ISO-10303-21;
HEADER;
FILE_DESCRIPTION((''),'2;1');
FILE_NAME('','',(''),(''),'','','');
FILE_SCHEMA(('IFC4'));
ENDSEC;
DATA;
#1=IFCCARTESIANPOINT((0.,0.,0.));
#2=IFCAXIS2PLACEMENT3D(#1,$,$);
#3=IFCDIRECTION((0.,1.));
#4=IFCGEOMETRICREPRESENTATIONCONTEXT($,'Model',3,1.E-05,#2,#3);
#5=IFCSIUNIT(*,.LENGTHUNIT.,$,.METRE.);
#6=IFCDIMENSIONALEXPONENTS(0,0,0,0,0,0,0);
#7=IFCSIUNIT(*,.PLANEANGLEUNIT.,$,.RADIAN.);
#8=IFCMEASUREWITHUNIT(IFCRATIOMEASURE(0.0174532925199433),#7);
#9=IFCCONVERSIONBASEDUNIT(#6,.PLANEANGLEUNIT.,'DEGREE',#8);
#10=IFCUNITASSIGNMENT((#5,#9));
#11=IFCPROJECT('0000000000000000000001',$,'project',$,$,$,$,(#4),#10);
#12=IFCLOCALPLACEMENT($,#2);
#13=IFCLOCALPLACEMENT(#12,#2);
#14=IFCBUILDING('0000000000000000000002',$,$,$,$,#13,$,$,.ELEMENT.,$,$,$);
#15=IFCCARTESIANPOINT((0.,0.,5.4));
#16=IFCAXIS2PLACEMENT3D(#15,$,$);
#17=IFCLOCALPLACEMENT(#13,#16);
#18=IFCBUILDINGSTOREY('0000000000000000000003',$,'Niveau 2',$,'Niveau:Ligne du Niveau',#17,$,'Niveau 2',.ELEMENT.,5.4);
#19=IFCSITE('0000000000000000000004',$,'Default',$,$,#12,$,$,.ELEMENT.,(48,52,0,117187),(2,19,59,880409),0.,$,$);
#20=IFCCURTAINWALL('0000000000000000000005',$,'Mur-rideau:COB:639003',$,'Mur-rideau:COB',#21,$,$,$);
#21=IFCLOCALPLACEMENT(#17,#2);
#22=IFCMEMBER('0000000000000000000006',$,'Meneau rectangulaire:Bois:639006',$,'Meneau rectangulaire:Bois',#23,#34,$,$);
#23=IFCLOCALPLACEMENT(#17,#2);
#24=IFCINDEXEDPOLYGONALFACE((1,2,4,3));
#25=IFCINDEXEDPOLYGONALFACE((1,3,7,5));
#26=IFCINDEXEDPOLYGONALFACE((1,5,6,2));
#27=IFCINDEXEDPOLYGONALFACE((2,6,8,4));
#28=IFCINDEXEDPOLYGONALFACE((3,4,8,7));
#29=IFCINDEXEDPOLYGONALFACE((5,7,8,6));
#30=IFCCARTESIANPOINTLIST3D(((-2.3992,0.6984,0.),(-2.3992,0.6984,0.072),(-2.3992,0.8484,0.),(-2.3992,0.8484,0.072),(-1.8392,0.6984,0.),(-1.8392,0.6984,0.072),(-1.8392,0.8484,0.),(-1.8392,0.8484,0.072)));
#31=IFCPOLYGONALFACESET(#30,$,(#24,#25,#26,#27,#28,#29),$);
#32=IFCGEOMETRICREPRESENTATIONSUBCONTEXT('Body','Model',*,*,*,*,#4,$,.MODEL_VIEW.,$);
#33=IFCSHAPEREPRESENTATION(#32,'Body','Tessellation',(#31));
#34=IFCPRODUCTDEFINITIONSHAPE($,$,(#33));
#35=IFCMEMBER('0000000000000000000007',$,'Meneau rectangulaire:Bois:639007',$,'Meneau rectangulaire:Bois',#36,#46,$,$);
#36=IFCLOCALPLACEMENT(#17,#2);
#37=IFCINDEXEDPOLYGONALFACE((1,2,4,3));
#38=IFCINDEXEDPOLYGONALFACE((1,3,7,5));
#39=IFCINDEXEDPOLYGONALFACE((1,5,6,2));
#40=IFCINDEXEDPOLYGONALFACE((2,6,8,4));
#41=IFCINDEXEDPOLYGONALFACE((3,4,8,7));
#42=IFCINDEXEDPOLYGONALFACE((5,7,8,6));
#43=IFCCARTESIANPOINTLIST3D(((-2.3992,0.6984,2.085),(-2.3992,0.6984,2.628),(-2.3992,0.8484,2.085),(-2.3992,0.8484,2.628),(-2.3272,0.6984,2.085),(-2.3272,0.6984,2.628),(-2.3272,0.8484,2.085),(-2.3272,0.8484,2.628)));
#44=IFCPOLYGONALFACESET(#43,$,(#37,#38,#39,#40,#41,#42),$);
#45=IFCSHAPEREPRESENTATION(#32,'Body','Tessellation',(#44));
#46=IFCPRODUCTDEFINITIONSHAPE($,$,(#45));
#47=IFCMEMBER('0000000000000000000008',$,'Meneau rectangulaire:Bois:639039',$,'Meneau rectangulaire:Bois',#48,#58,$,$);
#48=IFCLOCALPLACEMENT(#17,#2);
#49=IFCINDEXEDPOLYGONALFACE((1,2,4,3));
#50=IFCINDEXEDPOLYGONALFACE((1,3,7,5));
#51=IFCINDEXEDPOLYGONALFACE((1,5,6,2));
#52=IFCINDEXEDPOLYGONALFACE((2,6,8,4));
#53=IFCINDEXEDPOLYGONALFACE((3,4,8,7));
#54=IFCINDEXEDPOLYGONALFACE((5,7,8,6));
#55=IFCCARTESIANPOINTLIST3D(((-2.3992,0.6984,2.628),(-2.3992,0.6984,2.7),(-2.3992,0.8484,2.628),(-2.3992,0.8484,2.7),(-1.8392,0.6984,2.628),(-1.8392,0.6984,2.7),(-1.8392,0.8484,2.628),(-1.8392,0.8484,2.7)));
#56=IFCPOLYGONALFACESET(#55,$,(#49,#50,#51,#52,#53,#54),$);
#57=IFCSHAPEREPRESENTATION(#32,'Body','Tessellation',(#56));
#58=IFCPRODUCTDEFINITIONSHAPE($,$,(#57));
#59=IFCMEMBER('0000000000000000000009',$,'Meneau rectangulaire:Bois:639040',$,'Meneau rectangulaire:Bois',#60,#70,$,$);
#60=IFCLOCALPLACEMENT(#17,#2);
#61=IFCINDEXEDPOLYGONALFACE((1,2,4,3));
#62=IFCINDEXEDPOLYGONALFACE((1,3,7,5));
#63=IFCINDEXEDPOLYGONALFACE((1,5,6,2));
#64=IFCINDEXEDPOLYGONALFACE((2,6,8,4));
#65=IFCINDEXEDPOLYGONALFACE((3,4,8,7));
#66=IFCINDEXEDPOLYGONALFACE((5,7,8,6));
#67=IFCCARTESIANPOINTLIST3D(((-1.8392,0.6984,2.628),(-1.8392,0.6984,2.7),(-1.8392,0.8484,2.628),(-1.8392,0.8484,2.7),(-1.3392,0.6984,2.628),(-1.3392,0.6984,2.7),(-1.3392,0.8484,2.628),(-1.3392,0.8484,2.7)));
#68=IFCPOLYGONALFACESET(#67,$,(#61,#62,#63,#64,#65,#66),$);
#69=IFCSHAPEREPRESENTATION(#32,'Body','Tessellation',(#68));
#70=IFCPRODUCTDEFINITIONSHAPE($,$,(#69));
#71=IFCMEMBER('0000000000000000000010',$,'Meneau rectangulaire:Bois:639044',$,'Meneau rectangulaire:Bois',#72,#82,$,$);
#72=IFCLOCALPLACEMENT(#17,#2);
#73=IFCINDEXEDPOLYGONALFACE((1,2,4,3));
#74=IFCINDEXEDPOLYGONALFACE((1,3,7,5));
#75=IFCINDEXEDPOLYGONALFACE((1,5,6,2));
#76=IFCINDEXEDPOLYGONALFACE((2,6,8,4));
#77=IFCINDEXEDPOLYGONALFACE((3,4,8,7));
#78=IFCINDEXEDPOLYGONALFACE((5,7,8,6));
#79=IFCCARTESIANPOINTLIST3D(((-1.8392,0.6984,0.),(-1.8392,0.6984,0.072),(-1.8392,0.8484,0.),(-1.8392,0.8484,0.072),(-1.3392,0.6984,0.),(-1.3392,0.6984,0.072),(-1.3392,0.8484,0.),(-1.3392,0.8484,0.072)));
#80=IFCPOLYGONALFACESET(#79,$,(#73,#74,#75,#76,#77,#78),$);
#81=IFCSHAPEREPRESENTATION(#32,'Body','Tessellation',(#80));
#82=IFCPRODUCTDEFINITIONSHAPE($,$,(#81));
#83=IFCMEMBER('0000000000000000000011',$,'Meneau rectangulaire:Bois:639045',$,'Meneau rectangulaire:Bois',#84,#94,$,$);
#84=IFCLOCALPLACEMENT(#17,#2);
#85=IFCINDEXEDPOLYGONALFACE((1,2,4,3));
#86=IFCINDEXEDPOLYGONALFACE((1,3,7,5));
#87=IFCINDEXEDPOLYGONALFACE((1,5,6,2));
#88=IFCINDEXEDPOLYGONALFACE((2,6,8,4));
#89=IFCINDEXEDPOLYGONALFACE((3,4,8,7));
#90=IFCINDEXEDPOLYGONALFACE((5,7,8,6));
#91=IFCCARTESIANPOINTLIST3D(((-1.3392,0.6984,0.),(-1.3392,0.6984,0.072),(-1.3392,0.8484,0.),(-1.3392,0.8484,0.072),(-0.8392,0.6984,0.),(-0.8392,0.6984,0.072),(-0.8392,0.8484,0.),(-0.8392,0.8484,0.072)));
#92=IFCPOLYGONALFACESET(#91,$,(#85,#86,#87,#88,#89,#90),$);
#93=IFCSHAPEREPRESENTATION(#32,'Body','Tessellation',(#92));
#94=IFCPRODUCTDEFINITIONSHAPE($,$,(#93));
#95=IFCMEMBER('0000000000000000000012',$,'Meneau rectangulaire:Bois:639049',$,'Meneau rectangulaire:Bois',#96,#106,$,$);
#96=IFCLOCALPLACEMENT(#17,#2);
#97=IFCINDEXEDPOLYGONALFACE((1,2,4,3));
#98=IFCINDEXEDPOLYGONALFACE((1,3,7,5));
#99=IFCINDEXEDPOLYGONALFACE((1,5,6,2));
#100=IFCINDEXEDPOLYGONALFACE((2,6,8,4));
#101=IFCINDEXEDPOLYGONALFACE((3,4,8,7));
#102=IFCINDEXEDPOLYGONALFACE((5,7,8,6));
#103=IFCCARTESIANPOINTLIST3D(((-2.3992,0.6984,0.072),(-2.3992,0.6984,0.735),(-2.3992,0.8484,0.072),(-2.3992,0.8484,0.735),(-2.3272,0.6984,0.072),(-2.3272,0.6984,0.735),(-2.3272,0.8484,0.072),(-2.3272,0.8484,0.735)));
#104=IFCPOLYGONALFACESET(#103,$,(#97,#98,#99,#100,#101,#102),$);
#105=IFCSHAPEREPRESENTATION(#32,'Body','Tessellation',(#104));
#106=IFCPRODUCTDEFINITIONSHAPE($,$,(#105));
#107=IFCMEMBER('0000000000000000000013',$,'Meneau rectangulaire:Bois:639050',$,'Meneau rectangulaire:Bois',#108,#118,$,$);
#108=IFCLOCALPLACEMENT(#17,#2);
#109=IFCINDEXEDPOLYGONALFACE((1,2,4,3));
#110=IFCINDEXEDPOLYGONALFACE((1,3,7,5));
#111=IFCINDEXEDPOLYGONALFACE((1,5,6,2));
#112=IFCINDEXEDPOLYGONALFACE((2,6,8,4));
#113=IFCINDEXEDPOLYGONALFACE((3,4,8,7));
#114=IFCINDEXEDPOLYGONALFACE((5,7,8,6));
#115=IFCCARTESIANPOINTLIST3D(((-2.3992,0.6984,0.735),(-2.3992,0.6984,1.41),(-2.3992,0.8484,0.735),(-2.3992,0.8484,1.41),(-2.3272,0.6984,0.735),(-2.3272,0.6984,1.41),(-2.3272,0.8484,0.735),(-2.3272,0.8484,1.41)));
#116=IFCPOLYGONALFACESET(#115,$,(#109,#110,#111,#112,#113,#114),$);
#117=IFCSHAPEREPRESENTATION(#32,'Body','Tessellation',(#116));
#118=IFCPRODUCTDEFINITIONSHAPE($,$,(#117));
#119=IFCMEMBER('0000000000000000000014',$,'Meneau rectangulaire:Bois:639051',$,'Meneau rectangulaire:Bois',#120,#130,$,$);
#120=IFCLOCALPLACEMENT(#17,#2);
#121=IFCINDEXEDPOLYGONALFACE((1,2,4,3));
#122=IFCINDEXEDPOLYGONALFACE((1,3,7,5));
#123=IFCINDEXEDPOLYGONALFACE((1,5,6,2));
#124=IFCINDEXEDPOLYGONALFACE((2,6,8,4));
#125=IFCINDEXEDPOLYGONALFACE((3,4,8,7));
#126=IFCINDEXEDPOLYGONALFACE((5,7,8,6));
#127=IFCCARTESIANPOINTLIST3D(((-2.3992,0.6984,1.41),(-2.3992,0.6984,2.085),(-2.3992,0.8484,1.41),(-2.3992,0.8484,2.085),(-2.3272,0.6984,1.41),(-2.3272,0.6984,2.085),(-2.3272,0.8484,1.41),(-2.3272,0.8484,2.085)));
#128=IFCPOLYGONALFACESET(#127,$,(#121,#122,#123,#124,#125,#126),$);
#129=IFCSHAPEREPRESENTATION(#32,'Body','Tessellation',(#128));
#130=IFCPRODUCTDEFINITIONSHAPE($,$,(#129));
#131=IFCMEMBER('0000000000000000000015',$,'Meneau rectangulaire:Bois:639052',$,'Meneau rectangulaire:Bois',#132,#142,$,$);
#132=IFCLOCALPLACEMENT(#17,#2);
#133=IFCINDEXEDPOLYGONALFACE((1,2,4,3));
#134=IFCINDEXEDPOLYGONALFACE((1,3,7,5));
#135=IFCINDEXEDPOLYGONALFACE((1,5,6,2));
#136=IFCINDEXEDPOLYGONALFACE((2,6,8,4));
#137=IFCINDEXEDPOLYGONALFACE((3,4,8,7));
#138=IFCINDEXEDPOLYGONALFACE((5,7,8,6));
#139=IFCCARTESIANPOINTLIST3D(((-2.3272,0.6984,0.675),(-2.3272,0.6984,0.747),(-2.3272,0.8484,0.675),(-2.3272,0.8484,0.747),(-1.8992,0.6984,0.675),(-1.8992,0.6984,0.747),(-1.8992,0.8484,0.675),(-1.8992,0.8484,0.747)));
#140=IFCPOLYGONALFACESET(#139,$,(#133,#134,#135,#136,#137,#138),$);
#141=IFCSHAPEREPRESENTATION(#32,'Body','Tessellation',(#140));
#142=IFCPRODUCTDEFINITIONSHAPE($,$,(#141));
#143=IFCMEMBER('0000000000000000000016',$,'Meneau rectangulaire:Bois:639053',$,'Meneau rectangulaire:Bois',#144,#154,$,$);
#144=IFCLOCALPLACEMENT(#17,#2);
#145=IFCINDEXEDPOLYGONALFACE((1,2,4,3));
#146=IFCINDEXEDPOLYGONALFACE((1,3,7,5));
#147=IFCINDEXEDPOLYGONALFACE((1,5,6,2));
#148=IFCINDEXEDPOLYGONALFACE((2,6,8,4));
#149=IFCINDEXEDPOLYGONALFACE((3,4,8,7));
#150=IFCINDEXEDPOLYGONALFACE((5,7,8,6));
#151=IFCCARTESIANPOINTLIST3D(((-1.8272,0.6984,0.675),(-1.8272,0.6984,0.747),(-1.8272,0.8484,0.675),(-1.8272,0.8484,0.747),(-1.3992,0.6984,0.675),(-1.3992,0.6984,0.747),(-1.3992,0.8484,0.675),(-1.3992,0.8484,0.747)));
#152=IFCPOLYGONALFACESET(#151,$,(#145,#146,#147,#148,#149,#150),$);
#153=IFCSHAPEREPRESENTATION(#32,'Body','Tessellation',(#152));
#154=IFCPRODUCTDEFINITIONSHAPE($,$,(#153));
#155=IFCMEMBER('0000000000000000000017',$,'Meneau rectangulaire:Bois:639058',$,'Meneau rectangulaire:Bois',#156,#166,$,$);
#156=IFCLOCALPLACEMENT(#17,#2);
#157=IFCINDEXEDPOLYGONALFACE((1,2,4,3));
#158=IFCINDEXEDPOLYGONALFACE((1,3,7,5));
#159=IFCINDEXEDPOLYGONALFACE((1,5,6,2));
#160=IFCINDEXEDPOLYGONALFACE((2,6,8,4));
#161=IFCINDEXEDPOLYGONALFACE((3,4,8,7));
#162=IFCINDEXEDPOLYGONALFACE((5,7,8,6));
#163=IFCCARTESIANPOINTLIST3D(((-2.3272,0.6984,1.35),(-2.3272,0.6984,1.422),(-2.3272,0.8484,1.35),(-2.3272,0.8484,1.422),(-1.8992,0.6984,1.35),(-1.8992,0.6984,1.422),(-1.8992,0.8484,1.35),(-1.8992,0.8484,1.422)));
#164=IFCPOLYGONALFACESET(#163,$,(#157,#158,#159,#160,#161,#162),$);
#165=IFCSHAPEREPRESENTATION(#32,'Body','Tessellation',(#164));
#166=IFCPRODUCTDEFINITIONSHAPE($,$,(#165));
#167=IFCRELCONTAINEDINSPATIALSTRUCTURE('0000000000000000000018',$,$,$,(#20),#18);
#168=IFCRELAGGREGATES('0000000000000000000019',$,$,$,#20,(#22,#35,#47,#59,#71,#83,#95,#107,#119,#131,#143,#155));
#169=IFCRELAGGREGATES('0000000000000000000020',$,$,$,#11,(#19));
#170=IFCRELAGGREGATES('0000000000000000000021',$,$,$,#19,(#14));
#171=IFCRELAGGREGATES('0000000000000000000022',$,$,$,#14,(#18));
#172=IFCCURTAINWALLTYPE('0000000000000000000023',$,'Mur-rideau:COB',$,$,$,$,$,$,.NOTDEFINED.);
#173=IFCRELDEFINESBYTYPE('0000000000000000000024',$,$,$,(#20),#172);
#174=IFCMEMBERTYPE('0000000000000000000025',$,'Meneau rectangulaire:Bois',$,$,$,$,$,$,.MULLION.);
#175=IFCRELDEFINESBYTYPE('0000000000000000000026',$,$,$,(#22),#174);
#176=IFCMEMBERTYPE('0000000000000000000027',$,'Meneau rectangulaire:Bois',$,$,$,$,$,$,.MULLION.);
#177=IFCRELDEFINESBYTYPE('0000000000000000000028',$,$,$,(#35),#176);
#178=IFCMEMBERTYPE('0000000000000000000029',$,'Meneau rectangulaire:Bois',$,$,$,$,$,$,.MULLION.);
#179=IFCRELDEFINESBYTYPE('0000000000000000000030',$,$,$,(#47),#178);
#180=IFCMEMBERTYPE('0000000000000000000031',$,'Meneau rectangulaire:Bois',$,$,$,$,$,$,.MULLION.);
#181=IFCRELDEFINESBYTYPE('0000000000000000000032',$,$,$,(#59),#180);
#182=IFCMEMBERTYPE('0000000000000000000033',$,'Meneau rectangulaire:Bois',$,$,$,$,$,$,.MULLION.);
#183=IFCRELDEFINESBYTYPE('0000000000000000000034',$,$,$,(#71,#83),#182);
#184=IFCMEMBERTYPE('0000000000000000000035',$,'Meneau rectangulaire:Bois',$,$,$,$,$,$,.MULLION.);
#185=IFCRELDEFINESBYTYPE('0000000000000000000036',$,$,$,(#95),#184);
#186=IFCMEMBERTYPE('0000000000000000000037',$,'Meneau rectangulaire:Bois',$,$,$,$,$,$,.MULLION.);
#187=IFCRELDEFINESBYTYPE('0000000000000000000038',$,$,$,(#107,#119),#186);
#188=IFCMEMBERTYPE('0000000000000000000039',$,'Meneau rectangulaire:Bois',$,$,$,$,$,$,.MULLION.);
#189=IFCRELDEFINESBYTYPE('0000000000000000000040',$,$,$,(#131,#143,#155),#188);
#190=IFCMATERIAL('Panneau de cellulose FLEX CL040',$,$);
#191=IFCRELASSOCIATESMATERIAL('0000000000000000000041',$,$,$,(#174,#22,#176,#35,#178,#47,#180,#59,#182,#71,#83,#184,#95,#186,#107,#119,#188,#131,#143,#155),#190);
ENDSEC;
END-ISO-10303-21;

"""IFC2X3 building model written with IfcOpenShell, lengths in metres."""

from ifc_helpers import new_model, entity, si_unit, converted_unit, direction, frame, origin, origin_2d_with_axis, place, context, subcontext, project, spatial, rectangle, extrude, source, transform, mapped, material, type_object, type_shapes, element, aggregate, save


model = new_model("IFC2X3")

# Units and contexts
model_context = context("Model", 3, precision=1e-05, world=origin(), true_north=direction((0.0, 1.0)))
body_context = subcontext(model_context, "Body", "Model", "MODEL_VIEW")
ifc_project = project(units=[si_unit("LENGTHUNIT", "METRE"), converted_unit("PLANEANGLEUNIT", "DEGREE", entity("IfcRatioMeasure", 0.0174532925199433), si_unit("PLANEANGLEUNIT", "RADIAN"), dimensions=[0, 0, 0, 0, 0, 0, 0])], contexts=[model_context])

# Site, building, storey
site_placement = place(None, origin())
site = spatial("IfcSite", under=ifc_project, at=site_placement, Name="Default", CompositionType="ELEMENT", RefLatitude=(48, 52, 0, 117187), RefLongitude=(2, 19, 59, 880409), RefElevation=0.0)
building_placement = place(site_placement, origin())
building = spatial("IfcBuilding", under=site, at=building_placement, CompositionType="ELEMENT")
storey_placement = place(building_placement, frame((0.0, 0.0, 5.4)))
storey = spatial("IfcBuildingStorey", under=building, at=storey_placement, Name="Niveau 2", ObjectType="Niveau:Ligne du Niveau", LongName="Niveau 2", CompositionType="ELEMENT", Elevation=5.4)

# Curtain wall, members
curtain_wall_type_1 = type_object("IfcCurtainWallType", Name="Mur-rideau:COB", PredefinedType="NOTDEFINED")
curtain_wall_1_placement = place(storey_placement, frame((0.0, 0.0, -5.4)))
curtain_wall_1 = element("IfcCurtainWall", 1, at=curtain_wall_1_placement, inside=storey, type_object=curtain_wall_type_1, Name="Mur-rideau:COB:639003", ObjectType="Mur-rideau:COB")
ifc_material_1 = material(Name="Panneau de cellulose FLEX CL040")
member_type_1 = type_object("IfcMemberType", Name="Meneau rectangulaire:Bois", PredefinedType="MULLION", material=ifc_material_1)
shared_shape_1 = source(origin(), body_context, "Body", "SweptSolid", [
    extrude(rectangle(XDim=0.15, YDim=0.072, at=origin_2d_with_axis()), frame((-0.036, 0.0, -0.56), z_axis=(0.0, 0.0, 1.0), x_axis=(0.0, -1.0, 0.0)), (0.0, 0.0, 1.0), 0.56),
])
type_shapes(member_type_1, [shared_shape_1])
member_1_placement = place(storey_placement, frame((-2.3992, 0.7734, 0.0), z_axis=(-1.0, 0.0, 0.0), x_axis=(0.0, 0.0, -1.0)))
member_1 = element("IfcMember", 2, at=member_1_placement, type_object=member_type_1, material=ifc_material_1, Name="Meneau rectangulaire:Bois:639006", ObjectType="Meneau rectangulaire:Bois", context=body_context, shape_type="MappedRepresentation", body=[
    mapped(shared_shape_1, transform((0.0, 0.0, 0.0), scale=1.0)),
])
member_type_2 = type_object("IfcMemberType", Name="Meneau rectangulaire:Bois", PredefinedType="MULLION", material=ifc_material_1)
shared_shape_2 = source(origin(), body_context, "Body", "SweptSolid", [
    extrude(rectangle(XDim=0.15, YDim=0.072, at=origin_2d_with_axis()), frame((-0.036, 0.0, -0.543), z_axis=(0.0, 0.0, 1.0), x_axis=(0.0, -1.0, 0.0)), (0.0, 0.0, 1.0), 0.543),
])
type_shapes(member_type_2, [shared_shape_2])
member_2_placement = place(storey_placement, frame((-2.3992, 0.7734, 2.628), z_axis=(0.0, 0.0, 1.0), x_axis=(-1.0, 0.0, 0.0)))
member_2 = element("IfcMember", 3, at=member_2_placement, type_object=member_type_2, material=ifc_material_1, Name="Meneau rectangulaire:Bois:639007", ObjectType="Meneau rectangulaire:Bois", context=body_context, shape_type="MappedRepresentation", body=[
    mapped(shared_shape_2, transform((0.0, 0.0, 0.0), scale=1.0)),
])
member_type_3 = type_object("IfcMemberType", Name="Meneau rectangulaire:Bois", PredefinedType="MULLION", material=ifc_material_1)
shared_shape_3 = source(origin(), body_context, "Body", "SweptSolid", [
    extrude(rectangle(XDim=0.15, YDim=0.072, at=origin_2d_with_axis()), frame((-0.036, 0.0, -0.56), z_axis=(0.0, 0.0, 1.0), x_axis=(0.0, -1.0, 0.0)), (0.0, 0.0, 1.0), 0.56),
])
type_shapes(member_type_3, [shared_shape_3])
member_3_placement = place(storey_placement, frame((-1.8392, 0.7734, 2.7), z_axis=(1.0, 0.0, 0.0), x_axis=(0.0, 0.0, 1.0)))
member_3 = element("IfcMember", 4, at=member_3_placement, type_object=member_type_3, material=ifc_material_1, Name="Meneau rectangulaire:Bois:639039", ObjectType="Meneau rectangulaire:Bois", context=body_context, shape_type="MappedRepresentation", body=[
    mapped(shared_shape_3, transform((0.0, 0.0, 0.0), scale=1.0)),
])
member_type_4 = type_object("IfcMemberType", Name="Meneau rectangulaire:Bois", PredefinedType="MULLION", material=ifc_material_1)
shared_shape_4 = source(origin(), body_context, "Body", "SweptSolid", [
    extrude(rectangle(XDim=0.15, YDim=0.072, at=origin_2d_with_axis()), frame((-0.036, 0.0, -0.5), z_axis=(0.0, 0.0, 1.0), x_axis=(0.0, -1.0, 0.0)), (0.0, 0.0, 1.0), 0.5),
])
type_shapes(member_type_4, [shared_shape_4])
member_4_placement = place(storey_placement, frame((-1.3392, 0.7734, 2.7), z_axis=(1.0, 0.0, 0.0), x_axis=(0.0, 0.0, 1.0)))
member_4 = element("IfcMember", 5, at=member_4_placement, type_object=member_type_4, material=ifc_material_1, Name="Meneau rectangulaire:Bois:639040", ObjectType="Meneau rectangulaire:Bois", context=body_context, shape_type="MappedRepresentation", body=[
    mapped(shared_shape_4, transform((0.0, 0.0, 0.0), scale=1.0)),
])
member_type_5 = type_object("IfcMemberType", Name="Meneau rectangulaire:Bois", PredefinedType="MULLION", material=ifc_material_1)
shared_shape_5 = source(origin(), body_context, "Body", "SweptSolid", [
    extrude(rectangle(XDim=0.15, YDim=0.072, at=origin_2d_with_axis()), frame((-0.036, 0.0, -0.5), z_axis=(0.0, 0.0, 1.0), x_axis=(0.0, -1.0, 0.0)), (0.0, 0.0, 1.0), 0.5),
])
type_shapes(member_type_5, [shared_shape_5])
member_5_placement = place(storey_placement, frame((-1.8392, 0.7734, 0.0), z_axis=(-1.0, 0.0, 0.0), x_axis=(0.0, 0.0, -1.0)))
member_5 = element("IfcMember", 6, at=member_5_placement, type_object=member_type_5, material=ifc_material_1, Name="Meneau rectangulaire:Bois:639044", ObjectType="Meneau rectangulaire:Bois", context=body_context, shape_type="MappedRepresentation", body=[
    mapped(shared_shape_5, transform((0.0, 0.0, 0.0), scale=1.0)),
])
member_6_placement = place(storey_placement, frame((-1.3392, 0.7734, 0.0), z_axis=(-1.0, 0.0, 0.0), x_axis=(0.0, 0.0, -1.0)))
member_6 = element("IfcMember", 7, at=member_6_placement, type_object=member_type_5, material=ifc_material_1, Name="Meneau rectangulaire:Bois:639045", ObjectType="Meneau rectangulaire:Bois", context=body_context, shape_type="MappedRepresentation", body=[
    mapped(shared_shape_5, transform((0.0, 0.0, 0.0), scale=1.0)),
])
member_type_6 = type_object("IfcMemberType", Name="Meneau rectangulaire:Bois", PredefinedType="MULLION", material=ifc_material_1)
shared_shape_6 = source(origin(), body_context, "Body", "SweptSolid", [
    extrude(rectangle(XDim=0.15, YDim=0.072, at=origin_2d_with_axis()), frame((-0.036, 0.0, -0.663), z_axis=(0.0, 0.0, 1.0), x_axis=(0.0, -1.0, 0.0)), (0.0, 0.0, 1.0), 0.663),
])
type_shapes(member_type_6, [shared_shape_6])
member_7_placement = place(storey_placement, frame((-2.3992, 0.7734, 0.735), z_axis=(0.0, 0.0, 1.0), x_axis=(-1.0, 0.0, 0.0)))
member_7 = element("IfcMember", 8, at=member_7_placement, type_object=member_type_6, material=ifc_material_1, Name="Meneau rectangulaire:Bois:639049", ObjectType="Meneau rectangulaire:Bois", context=body_context, shape_type="MappedRepresentation", body=[
    mapped(shared_shape_6, transform((0.0, 0.0, 0.0), scale=1.0)),
])
member_type_7 = type_object("IfcMemberType", Name="Meneau rectangulaire:Bois", PredefinedType="MULLION", material=ifc_material_1)
shared_shape_7 = source(origin(), body_context, "Body", "SweptSolid", [
    extrude(rectangle(XDim=0.15, YDim=0.072, at=origin_2d_with_axis()), frame((-0.036, 0.0, -0.675), z_axis=(0.0, 0.0, 1.0), x_axis=(0.0, -1.0, 0.0)), (0.0, 0.0, 1.0), 0.675),
])
type_shapes(member_type_7, [shared_shape_7])
member_8_placement = place(storey_placement, frame((-2.3992, 0.7734, 1.41), z_axis=(0.0, 0.0, 1.0), x_axis=(-1.0, 0.0, 0.0)))
member_8 = element("IfcMember", 9, at=member_8_placement, type_object=member_type_7, material=ifc_material_1, Name="Meneau rectangulaire:Bois:639050", ObjectType="Meneau rectangulaire:Bois", context=body_context, shape_type="MappedRepresentation", body=[
    mapped(shared_shape_7, transform((0.0, 0.0, 0.0), scale=1.0)),
])
member_9_placement = place(storey_placement, frame((-2.3992, 0.7734, 2.085), z_axis=(0.0, 0.0, 1.0), x_axis=(-1.0, 0.0, 0.0)))
member_9 = element("IfcMember", 10, at=member_9_placement, type_object=member_type_7, material=ifc_material_1, Name="Meneau rectangulaire:Bois:639051", ObjectType="Meneau rectangulaire:Bois", context=body_context, shape_type="MappedRepresentation", body=[
    mapped(shared_shape_7, transform((0.0, 0.0, 0.0), scale=1.0)),
])
member_type_8 = type_object("IfcMemberType", Name="Meneau rectangulaire:Bois", PredefinedType="MULLION", material=ifc_material_1)
shared_shape_8 = source(origin(), body_context, "Body", "SweptSolid", [
    extrude(rectangle(XDim=0.15, YDim=0.072, at=origin_2d_with_axis()), frame((-0.024, 0.0, -0.428), z_axis=(0.0, 0.0, 1.0), x_axis=(0.0, -1.0, 0.0)), (0.0, 0.0, 1.0), 0.428),
])
type_shapes(member_type_8, [shared_shape_8])
member_10_placement = place(storey_placement, frame((-1.8992, 0.7734, 0.735), z_axis=(1.0, 0.0, 0.0), x_axis=(0.0, 0.0, 1.0)))
member_10 = element("IfcMember", 11, at=member_10_placement, type_object=member_type_8, material=ifc_material_1, Name="Meneau rectangulaire:Bois:639052", ObjectType="Meneau rectangulaire:Bois", context=body_context, shape_type="MappedRepresentation", body=[
    mapped(shared_shape_8, transform((0.0, 0.0, 0.0), scale=1.0)),
])
member_11_placement = place(storey_placement, frame((-1.3992, 0.7734, 0.735), z_axis=(1.0, 0.0, 0.0), x_axis=(0.0, 0.0, 1.0)))
member_11 = element("IfcMember", 12, at=member_11_placement, type_object=member_type_8, material=ifc_material_1, Name="Meneau rectangulaire:Bois:639053", ObjectType="Meneau rectangulaire:Bois", context=body_context, shape_type="MappedRepresentation", body=[
    mapped(shared_shape_8, transform((0.0, 0.0, 0.0), scale=1.0)),
])
member_12_placement = place(storey_placement, frame((-1.8992, 0.7734, 1.41), z_axis=(1.0, 0.0, 0.0), x_axis=(0.0, 0.0, 1.0)))
member_12 = element("IfcMember", 13, at=member_12_placement, type_object=member_type_8, material=ifc_material_1, Name="Meneau rectangulaire:Bois:639058", ObjectType="Meneau rectangulaire:Bois", context=body_context, shape_type="MappedRepresentation", body=[
    mapped(shared_shape_8, transform((0.0, 0.0, 0.0), scale=1.0)),
])
aggregate(curtain_wall_1, [member_1, member_2, member_3, member_4, member_5, member_6, member_7, member_8, member_9, member_10, member_11, member_12])

save(model, "model.ifc")
